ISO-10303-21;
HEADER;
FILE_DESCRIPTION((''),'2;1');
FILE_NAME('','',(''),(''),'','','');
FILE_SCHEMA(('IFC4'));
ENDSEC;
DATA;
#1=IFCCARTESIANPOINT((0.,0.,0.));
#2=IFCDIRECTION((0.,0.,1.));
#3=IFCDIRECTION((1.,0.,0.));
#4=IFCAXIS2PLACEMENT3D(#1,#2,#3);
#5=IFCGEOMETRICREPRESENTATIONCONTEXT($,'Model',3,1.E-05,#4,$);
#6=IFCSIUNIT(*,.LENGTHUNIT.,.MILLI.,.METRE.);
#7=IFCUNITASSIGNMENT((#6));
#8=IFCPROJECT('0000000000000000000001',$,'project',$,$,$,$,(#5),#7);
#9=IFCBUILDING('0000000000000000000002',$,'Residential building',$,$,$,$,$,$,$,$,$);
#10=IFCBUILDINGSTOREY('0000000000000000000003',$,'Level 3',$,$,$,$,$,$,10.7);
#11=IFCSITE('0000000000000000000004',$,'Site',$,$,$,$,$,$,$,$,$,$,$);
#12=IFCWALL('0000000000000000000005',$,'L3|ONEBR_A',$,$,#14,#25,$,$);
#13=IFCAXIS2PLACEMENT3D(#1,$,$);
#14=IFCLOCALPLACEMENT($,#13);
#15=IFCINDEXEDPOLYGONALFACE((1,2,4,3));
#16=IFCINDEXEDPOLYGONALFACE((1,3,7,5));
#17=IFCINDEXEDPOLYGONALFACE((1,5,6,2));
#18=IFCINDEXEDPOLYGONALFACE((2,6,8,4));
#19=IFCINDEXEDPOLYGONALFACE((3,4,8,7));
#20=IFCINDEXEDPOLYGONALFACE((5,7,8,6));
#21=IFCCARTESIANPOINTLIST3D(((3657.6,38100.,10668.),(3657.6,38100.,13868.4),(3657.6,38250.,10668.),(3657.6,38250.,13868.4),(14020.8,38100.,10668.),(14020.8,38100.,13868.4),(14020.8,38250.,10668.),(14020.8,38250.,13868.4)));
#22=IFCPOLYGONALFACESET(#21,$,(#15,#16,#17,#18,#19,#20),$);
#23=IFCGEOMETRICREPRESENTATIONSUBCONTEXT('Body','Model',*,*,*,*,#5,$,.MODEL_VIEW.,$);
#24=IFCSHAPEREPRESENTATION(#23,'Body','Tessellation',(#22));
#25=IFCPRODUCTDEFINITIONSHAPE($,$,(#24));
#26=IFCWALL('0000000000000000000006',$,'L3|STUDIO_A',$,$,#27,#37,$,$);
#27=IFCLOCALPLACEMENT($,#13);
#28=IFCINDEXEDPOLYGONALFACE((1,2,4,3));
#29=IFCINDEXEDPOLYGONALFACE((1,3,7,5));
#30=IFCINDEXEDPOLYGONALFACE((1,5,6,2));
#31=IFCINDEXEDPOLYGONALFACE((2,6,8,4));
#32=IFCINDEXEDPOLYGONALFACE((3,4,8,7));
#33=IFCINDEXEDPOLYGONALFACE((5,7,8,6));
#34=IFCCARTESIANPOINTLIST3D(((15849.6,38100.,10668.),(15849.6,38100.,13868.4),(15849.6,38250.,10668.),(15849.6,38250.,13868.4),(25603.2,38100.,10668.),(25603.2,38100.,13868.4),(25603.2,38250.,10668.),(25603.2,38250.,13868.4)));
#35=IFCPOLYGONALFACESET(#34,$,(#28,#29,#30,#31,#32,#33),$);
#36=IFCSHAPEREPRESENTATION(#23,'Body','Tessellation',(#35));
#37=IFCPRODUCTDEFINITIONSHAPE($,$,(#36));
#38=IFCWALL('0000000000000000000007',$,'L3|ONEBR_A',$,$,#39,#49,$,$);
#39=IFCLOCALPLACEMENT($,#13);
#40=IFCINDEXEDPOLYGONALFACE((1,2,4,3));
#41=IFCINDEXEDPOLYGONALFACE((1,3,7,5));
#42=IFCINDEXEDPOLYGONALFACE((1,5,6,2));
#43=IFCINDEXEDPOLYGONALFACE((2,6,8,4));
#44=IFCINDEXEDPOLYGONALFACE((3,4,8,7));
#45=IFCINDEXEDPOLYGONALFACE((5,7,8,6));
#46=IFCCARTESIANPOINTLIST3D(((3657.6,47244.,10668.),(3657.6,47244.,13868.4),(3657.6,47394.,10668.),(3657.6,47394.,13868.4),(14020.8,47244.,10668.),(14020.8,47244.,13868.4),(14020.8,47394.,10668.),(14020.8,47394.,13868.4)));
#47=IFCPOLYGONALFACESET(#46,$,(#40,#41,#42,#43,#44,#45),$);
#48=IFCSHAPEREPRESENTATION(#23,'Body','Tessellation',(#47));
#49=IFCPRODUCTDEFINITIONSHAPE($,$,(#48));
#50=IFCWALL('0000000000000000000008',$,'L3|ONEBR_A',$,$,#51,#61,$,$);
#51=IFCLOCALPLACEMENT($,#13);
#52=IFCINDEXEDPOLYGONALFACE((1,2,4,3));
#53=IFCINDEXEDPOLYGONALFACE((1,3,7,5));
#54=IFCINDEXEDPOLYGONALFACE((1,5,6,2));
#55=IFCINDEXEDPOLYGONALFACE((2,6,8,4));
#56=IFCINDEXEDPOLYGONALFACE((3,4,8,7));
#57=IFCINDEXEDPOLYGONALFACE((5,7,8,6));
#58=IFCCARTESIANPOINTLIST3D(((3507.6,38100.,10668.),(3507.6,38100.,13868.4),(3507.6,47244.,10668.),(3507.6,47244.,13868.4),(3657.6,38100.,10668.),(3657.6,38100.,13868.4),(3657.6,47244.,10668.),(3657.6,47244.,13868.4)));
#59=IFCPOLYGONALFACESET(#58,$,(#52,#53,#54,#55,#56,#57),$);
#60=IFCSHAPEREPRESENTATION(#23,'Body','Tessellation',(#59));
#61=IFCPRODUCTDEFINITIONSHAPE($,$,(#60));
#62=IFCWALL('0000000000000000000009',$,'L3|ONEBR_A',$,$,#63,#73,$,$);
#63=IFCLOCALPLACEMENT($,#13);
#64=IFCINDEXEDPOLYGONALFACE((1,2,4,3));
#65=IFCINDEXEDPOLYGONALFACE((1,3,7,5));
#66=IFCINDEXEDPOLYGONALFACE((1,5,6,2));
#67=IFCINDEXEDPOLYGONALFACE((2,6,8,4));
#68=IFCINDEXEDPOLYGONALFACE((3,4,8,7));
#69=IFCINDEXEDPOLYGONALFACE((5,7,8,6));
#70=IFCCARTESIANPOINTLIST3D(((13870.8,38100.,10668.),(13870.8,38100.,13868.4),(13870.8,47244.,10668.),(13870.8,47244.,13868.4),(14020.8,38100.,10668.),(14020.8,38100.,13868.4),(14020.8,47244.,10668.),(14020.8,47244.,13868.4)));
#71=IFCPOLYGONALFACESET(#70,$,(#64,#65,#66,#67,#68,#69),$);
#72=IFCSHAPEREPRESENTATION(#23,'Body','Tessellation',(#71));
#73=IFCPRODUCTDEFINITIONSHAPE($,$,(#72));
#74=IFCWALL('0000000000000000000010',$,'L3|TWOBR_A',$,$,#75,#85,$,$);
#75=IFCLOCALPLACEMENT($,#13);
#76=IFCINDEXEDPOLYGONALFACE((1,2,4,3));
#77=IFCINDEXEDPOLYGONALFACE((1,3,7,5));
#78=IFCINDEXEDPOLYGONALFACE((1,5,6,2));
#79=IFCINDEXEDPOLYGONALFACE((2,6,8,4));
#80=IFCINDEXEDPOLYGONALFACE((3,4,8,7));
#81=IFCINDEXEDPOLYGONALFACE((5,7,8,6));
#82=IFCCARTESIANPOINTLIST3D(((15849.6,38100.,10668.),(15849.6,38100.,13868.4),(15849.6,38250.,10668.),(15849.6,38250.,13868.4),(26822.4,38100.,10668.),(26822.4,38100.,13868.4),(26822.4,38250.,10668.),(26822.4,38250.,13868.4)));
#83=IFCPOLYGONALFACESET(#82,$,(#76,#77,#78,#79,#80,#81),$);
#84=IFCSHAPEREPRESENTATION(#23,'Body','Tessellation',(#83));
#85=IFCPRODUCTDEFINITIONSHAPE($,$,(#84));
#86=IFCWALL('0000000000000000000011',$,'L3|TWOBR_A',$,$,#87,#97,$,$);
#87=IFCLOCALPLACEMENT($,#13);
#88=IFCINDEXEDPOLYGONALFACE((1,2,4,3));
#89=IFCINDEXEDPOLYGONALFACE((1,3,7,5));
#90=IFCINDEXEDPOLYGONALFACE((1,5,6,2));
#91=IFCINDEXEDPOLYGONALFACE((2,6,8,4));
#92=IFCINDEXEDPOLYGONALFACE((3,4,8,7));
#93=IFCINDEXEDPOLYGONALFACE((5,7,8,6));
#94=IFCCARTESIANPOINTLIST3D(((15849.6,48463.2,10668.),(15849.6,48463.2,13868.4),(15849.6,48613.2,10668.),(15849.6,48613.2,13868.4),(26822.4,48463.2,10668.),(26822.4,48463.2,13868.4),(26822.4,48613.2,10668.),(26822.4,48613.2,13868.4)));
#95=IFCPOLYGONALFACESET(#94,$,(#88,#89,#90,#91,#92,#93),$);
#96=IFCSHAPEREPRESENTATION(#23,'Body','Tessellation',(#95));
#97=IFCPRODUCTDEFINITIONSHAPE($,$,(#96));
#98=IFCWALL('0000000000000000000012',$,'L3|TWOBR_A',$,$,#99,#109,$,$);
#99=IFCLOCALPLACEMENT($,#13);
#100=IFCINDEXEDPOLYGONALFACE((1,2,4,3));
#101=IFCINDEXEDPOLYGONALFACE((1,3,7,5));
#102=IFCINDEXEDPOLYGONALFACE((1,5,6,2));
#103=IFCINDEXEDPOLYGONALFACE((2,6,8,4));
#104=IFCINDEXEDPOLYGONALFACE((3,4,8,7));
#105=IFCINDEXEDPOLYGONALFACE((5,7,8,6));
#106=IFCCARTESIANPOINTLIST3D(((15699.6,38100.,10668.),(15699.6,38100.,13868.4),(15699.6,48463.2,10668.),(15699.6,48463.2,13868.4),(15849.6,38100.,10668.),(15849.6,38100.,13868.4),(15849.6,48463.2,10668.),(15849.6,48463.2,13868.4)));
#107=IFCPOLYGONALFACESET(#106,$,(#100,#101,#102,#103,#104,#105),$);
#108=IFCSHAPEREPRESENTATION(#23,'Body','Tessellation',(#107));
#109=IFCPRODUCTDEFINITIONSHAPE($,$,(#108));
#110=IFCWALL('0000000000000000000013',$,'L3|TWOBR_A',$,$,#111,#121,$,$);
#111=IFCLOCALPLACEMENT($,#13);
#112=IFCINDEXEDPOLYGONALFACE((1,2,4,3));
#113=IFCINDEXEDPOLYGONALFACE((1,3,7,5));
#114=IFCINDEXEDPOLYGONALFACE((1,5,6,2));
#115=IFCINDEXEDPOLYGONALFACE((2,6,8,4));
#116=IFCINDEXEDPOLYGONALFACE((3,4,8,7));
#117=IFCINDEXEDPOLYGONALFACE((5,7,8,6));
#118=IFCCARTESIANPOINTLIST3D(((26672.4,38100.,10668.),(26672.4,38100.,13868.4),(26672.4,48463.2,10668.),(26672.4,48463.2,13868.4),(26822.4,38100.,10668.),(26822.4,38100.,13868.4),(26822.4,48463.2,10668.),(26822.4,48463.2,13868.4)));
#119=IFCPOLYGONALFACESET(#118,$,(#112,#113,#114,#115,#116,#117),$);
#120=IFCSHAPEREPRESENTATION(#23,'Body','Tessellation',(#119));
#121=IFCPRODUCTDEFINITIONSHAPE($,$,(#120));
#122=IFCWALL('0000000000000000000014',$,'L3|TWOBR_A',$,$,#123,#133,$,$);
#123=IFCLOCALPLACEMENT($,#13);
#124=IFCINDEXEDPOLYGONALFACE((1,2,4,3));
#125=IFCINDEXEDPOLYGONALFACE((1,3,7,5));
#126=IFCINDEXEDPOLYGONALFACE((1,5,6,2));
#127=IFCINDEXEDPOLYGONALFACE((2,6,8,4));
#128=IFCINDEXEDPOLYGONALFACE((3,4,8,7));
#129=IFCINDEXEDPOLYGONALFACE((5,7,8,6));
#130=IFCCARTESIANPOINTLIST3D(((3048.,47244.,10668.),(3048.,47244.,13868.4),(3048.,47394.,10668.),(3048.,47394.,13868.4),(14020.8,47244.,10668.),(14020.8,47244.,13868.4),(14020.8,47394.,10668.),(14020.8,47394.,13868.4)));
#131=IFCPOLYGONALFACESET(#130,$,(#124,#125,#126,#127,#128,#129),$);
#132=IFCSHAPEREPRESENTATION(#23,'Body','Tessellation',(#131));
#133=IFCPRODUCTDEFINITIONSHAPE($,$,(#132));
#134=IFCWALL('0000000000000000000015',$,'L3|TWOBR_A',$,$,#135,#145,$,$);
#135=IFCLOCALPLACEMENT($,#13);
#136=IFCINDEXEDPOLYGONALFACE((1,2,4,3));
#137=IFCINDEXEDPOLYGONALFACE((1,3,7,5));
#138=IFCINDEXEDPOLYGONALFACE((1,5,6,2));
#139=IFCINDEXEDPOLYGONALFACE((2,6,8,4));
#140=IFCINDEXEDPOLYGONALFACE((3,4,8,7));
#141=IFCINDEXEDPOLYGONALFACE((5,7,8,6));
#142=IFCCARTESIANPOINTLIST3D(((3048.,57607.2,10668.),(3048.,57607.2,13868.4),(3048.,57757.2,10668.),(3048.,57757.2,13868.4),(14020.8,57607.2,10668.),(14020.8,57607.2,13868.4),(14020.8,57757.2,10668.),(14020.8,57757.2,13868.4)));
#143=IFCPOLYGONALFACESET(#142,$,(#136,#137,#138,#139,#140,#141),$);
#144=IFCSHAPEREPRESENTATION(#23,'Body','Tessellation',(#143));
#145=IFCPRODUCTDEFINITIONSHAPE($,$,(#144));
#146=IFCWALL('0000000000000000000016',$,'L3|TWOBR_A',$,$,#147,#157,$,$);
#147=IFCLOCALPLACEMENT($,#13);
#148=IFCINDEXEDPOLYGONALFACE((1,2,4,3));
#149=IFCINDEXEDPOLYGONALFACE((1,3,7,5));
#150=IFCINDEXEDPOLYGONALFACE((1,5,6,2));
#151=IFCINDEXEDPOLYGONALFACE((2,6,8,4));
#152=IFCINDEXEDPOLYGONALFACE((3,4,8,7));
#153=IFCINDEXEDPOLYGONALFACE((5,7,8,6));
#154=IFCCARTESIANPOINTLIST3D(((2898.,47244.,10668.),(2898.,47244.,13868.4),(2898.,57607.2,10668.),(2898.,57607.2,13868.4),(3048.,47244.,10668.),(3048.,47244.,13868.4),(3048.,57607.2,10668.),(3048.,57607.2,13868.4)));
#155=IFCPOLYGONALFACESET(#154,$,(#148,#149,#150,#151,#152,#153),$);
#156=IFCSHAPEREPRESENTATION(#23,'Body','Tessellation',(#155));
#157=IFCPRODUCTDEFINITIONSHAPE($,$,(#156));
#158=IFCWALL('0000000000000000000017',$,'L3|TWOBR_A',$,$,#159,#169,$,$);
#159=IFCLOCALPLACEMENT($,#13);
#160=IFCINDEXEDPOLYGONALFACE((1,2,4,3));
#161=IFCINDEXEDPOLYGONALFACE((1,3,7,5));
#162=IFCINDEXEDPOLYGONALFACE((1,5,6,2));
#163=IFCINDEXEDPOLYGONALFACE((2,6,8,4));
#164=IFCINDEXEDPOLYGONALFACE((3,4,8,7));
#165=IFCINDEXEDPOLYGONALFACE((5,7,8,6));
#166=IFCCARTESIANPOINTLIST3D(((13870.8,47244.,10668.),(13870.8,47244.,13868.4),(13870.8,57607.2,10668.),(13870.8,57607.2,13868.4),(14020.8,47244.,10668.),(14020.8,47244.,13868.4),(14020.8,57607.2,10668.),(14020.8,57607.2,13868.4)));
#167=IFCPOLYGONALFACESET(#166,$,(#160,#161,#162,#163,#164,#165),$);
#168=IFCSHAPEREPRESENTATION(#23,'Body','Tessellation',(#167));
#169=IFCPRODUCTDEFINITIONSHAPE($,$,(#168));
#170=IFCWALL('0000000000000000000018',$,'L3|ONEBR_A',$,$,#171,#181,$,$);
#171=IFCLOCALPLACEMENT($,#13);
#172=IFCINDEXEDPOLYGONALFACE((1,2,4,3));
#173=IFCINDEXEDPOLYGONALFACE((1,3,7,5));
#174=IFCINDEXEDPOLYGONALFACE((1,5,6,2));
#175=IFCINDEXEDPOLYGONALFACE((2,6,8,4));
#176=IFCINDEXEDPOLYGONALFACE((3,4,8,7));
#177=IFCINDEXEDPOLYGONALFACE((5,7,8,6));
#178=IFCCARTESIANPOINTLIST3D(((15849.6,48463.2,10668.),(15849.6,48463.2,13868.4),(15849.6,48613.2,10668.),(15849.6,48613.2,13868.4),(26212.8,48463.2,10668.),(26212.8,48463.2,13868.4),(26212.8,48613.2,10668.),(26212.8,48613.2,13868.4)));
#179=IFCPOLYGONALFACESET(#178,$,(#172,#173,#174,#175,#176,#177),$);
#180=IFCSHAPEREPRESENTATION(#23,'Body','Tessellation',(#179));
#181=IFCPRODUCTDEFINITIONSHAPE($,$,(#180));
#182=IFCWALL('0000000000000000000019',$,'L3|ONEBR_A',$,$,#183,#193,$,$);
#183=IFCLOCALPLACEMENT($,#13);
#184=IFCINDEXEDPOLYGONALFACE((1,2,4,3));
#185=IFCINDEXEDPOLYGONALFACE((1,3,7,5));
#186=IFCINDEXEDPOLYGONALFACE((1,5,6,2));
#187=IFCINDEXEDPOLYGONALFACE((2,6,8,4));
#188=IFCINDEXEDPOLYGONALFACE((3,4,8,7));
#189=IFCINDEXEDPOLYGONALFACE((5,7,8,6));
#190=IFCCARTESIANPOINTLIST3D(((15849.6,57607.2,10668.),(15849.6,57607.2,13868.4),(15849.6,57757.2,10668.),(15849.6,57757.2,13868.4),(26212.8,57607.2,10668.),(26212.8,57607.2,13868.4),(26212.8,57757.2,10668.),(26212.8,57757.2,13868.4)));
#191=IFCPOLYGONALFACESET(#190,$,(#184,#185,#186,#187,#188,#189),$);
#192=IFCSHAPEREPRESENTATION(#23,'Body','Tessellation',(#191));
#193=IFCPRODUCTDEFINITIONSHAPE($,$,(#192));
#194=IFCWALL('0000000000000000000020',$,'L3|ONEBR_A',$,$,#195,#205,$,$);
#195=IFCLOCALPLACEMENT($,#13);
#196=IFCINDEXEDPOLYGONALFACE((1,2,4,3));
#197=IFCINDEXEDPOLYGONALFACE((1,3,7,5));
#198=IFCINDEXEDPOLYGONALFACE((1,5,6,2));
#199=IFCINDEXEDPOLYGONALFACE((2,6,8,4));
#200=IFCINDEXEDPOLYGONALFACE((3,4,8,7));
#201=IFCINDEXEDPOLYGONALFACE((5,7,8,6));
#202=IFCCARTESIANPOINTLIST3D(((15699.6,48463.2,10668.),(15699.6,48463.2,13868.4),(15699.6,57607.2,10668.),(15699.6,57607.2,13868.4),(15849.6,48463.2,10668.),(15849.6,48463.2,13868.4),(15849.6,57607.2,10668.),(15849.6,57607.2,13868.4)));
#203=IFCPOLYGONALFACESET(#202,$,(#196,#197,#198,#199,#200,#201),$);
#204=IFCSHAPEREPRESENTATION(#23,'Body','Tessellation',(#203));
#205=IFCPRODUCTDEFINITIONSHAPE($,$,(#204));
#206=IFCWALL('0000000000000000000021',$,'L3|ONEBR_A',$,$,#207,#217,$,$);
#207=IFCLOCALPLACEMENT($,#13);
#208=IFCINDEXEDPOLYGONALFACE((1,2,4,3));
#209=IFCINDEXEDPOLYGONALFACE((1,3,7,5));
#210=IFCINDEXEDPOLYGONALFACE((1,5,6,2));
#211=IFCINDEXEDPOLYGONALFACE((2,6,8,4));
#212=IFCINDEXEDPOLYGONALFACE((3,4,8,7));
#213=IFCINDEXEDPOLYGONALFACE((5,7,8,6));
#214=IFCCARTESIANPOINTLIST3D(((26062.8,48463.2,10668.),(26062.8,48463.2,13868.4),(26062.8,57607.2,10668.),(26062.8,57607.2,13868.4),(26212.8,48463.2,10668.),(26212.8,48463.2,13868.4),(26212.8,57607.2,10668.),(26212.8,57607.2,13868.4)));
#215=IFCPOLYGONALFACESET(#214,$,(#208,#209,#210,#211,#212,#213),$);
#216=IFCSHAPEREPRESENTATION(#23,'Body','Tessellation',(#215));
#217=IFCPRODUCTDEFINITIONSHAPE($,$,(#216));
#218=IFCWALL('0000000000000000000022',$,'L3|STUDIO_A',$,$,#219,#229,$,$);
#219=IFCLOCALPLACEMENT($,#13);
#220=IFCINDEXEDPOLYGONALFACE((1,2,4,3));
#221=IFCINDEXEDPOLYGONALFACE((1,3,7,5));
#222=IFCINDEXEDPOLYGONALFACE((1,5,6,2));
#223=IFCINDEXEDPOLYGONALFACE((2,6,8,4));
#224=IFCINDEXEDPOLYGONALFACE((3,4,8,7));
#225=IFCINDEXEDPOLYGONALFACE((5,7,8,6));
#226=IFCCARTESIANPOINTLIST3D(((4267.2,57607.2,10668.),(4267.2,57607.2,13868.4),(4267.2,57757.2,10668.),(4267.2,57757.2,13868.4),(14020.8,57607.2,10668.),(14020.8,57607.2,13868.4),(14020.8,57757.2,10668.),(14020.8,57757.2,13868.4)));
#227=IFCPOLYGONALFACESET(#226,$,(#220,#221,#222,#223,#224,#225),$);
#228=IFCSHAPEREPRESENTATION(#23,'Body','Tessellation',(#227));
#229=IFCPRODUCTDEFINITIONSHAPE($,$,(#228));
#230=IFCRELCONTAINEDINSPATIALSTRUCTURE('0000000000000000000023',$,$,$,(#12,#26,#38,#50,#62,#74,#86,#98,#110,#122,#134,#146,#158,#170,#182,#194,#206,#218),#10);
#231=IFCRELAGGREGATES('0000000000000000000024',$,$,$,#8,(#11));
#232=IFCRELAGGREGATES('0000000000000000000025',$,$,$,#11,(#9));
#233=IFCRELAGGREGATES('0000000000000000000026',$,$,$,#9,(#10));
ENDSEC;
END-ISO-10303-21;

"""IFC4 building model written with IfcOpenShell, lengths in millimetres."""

from ifc_helpers import new_model, si_unit, frame, origin_with_axes, place, context, subcontext, project, spatial, indexed_curve, outline, extrude, element, save


model = new_model("IFC4")

# Units and contexts
model_context = context("Model", 3, precision=1e-05, world=origin_with_axes())
body_context = subcontext(model_context, "Body", "Model", "MODEL_VIEW")
ifc_project = project(units=[si_unit("LENGTHUNIT", "METRE", prefix="MILLI")], contexts=[model_context])

# Site, building, storey
site = spatial("IfcSite", under=ifc_project, Name="Site")
building = spatial("IfcBuilding", under=site, Name="Residential building")
storey = spatial("IfcBuildingStorey", under=building, Name="Level 3", Elevation=10.7)

# Walls
wall_1_placement = place(None, frame((3657.6, 38100.0, 10668.0), z_axis=(0.0, 0.0, 1.0), x_axis=(1.0, 0.0, 0.0)))
element("IfcWall", 1, at=wall_1_placement, inside=storey, Name="L3|ONEBR_A", context=body_context, shape_type="SweptSolid", body=[
    extrude(outline(indexed_curve([(0.0, 0.0), (0.0, 150.0), (10363.2, 150.0), (10363.2, 0.0), (0.0, 0.0)], self_intersect=False)), origin_with_axes(), (0.0, 0.0, 1.0), 3200.4),
])
wall_2_placement = place(None, frame((15849.6, 38100.0, 10668.0), z_axis=(0.0, 0.0, 1.0), x_axis=(1.0, 0.0, 0.0)))
element("IfcWall", 2, at=wall_2_placement, inside=storey, Name="L3|STUDIO_A", context=body_context, shape_type="SweptSolid", body=[
    extrude(outline(indexed_curve([(0.0, 0.0), (0.0, 150.0), (9753.6, 150.0), (9753.6, 0.0), (0.0, 0.0)], self_intersect=False)), origin_with_axes(), (0.0, 0.0, 1.0), 3200.4),
])
for number, where, z_axis, x_axis, name in (
    (3, (3657.6, 47244.0, 10668.0), (0.0, 0.0, 1.0), (1.0, 0.0, 0.0), "L3|ONEBR_A"),
):
    element("IfcWall", number, at=place(None, frame(where, z_axis=z_axis, x_axis=x_axis)), inside=storey, Name=name, context=body_context, shape_type="SweptSolid", body=[
        extrude(outline(indexed_curve([(0.0, 0.0), (0.0, 150.0), (10363.2, 150.0), (10363.2, 0.0), (0.0, 0.0)], self_intersect=False)), origin_with_axes(), (0.0, 0.0, 1.0), 3200.4),
    ])
for number, where, z_axis, x_axis, name in (
    (4, (3657.6, 38100.0, 10668.0), (0.0, 0.0, 1.0), (0.0, 1.0, 0.0), "L3|ONEBR_A"),
    (5, (14020.8, 38100.0, 10668.0), (0.0, 0.0, 1.0), (0.0, 1.0, 0.0), "L3|ONEBR_A"),
):
    element("IfcWall", number, at=place(None, frame(where, z_axis=z_axis, x_axis=x_axis)), inside=storey, Name=name, context=body_context, shape_type="SweptSolid", body=[
        extrude(outline(indexed_curve([(0.0, 0.0), (0.0, 150.0), (9144.0, 150.0), (9144.0, 0.0), (0.0, 0.0)], self_intersect=False)), origin_with_axes(), (0.0, 0.0, 1.0), 3200.4),
    ])
for number, where, z_axis, x_axis, name in (
    (6, (15849.6, 38100.0, 10668.0), (0.0, 0.0, 1.0), (1.0, 0.0, 0.0), "L3|TWOBR_A"),
    (7, (15849.6, 48463.2, 10668.0), (0.0, 0.0, 1.0), (1.0, 0.0, 0.0), "L3|TWOBR_A"),
):
    element("IfcWall", number, at=place(None, frame(where, z_axis=z_axis, x_axis=x_axis)), inside=storey, Name=name, context=body_context, shape_type="SweptSolid", body=[
        extrude(outline(indexed_curve([(0.0, 0.0), (0.0, 150.0), (10972.8, 150.0), (10972.8, 0.0), (0.0, 0.0)], self_intersect=False)), origin_with_axes(), (0.0, 0.0, 1.0), 3200.4),
    ])
for number, where, z_axis, x_axis, name in (
    (8, (15849.6, 38100.0, 10668.0), (0.0, 0.0, 1.0), (0.0, 1.0, 0.0), "L3|TWOBR_A"),
    (9, (26822.4, 38100.0, 10668.0), (0.0, 0.0, 1.0), (0.0, 1.0, 0.0), "L3|TWOBR_A"),
):
    element("IfcWall", number, at=place(None, frame(where, z_axis=z_axis, x_axis=x_axis)), inside=storey, Name=name, context=body_context, shape_type="SweptSolid", body=[
        extrude(outline(indexed_curve([(0.0, 0.0), (0.0, 150.0), (10363.2, 150.0), (10363.2, 0.0), (0.0, 0.0)], self_intersect=False)), origin_with_axes(), (0.0, 0.0, 1.0), 3200.4),
    ])
for number, where, z_axis, x_axis, name in (
    (10, (3048.0, 47244.0, 10668.0), (0.0, 0.0, 1.0), (1.0, 0.0, 0.0), "L3|TWOBR_A"),
    (11, (3048.0, 57607.2, 10668.0), (0.0, 0.0, 1.0), (1.0, 0.0, 0.0), "L3|TWOBR_A"),
):
    element("IfcWall", number, at=place(None, frame(where, z_axis=z_axis, x_axis=x_axis)), inside=storey, Name=name, context=body_context, shape_type="SweptSolid", body=[
        extrude(outline(indexed_curve([(0.0, 0.0), (0.0, 150.0), (10972.8, 150.0), (10972.8, 0.0), (0.0, 0.0)], self_intersect=False)), origin_with_axes(), (0.0, 0.0, 1.0), 3200.4),
    ])
for number, where, z_axis, x_axis, name in (
    (12, (3048.0, 47244.0, 10668.0), (0.0, 0.0, 1.0), (0.0, 1.0, 0.0), "L3|TWOBR_A"),
    (13, (14020.8, 47244.0, 10668.0), (0.0, 0.0, 1.0), (0.0, 1.0, 0.0), "L3|TWOBR_A"),
    (14, (15849.6, 48463.2, 10668.0), (0.0, 0.0, 1.0), (1.0, 0.0, 0.0), "L3|ONEBR_A"),
    (15, (15849.6, 57607.2, 10668.0), (0.0, 0.0, 1.0), (1.0, 0.0, 0.0), "L3|ONEBR_A"),
):
    element("IfcWall", number, at=place(None, frame(where, z_axis=z_axis, x_axis=x_axis)), inside=storey, Name=name, context=body_context, shape_type="SweptSolid", body=[
        extrude(outline(indexed_curve([(0.0, 0.0), (0.0, 150.0), (10363.2, 150.0), (10363.2, 0.0), (0.0, 0.0)], self_intersect=False)), origin_with_axes(), (0.0, 0.0, 1.0), 3200.4),
    ])
for number, where, z_axis, x_axis, name in (
    (16, (15849.6, 48463.2, 10668.0), (0.0, 0.0, 1.0), (0.0, 1.0, 0.0), "L3|ONEBR_A"),
    (17, (26212.8, 48463.2, 10668.0), (0.0, 0.0, 1.0), (0.0, 1.0, 0.0), "L3|ONEBR_A"),
):
    element("IfcWall", number, at=place(None, frame(where, z_axis=z_axis, x_axis=x_axis)), inside=storey, Name=name, context=body_context, shape_type="SweptSolid", body=[
        extrude(outline(indexed_curve([(0.0, 0.0), (0.0, 150.0), (9144.0, 150.0), (9144.0, 0.0), (0.0, 0.0)], self_intersect=False)), origin_with_axes(), (0.0, 0.0, 1.0), 3200.4),
    ])
for number, where, z_axis, x_axis, name in (
    (18, (4267.2, 57607.2, 10668.0), (0.0, 0.0, 1.0), (1.0, 0.0, 0.0), "L3|STUDIO_A"),
):
    element("IfcWall", number, at=place(None, frame(where, z_axis=z_axis, x_axis=x_axis)), inside=storey, Name=name, context=body_context, shape_type="SweptSolid", body=[
        extrude(outline(indexed_curve([(0.0, 0.0), (0.0, 150.0), (9753.6, 150.0), (9753.6, 0.0), (0.0, 0.0)], self_intersect=False)), origin_with_axes(), (0.0, 0.0, 1.0), 3200.4),
    ])

save(model, "model.ifc")
